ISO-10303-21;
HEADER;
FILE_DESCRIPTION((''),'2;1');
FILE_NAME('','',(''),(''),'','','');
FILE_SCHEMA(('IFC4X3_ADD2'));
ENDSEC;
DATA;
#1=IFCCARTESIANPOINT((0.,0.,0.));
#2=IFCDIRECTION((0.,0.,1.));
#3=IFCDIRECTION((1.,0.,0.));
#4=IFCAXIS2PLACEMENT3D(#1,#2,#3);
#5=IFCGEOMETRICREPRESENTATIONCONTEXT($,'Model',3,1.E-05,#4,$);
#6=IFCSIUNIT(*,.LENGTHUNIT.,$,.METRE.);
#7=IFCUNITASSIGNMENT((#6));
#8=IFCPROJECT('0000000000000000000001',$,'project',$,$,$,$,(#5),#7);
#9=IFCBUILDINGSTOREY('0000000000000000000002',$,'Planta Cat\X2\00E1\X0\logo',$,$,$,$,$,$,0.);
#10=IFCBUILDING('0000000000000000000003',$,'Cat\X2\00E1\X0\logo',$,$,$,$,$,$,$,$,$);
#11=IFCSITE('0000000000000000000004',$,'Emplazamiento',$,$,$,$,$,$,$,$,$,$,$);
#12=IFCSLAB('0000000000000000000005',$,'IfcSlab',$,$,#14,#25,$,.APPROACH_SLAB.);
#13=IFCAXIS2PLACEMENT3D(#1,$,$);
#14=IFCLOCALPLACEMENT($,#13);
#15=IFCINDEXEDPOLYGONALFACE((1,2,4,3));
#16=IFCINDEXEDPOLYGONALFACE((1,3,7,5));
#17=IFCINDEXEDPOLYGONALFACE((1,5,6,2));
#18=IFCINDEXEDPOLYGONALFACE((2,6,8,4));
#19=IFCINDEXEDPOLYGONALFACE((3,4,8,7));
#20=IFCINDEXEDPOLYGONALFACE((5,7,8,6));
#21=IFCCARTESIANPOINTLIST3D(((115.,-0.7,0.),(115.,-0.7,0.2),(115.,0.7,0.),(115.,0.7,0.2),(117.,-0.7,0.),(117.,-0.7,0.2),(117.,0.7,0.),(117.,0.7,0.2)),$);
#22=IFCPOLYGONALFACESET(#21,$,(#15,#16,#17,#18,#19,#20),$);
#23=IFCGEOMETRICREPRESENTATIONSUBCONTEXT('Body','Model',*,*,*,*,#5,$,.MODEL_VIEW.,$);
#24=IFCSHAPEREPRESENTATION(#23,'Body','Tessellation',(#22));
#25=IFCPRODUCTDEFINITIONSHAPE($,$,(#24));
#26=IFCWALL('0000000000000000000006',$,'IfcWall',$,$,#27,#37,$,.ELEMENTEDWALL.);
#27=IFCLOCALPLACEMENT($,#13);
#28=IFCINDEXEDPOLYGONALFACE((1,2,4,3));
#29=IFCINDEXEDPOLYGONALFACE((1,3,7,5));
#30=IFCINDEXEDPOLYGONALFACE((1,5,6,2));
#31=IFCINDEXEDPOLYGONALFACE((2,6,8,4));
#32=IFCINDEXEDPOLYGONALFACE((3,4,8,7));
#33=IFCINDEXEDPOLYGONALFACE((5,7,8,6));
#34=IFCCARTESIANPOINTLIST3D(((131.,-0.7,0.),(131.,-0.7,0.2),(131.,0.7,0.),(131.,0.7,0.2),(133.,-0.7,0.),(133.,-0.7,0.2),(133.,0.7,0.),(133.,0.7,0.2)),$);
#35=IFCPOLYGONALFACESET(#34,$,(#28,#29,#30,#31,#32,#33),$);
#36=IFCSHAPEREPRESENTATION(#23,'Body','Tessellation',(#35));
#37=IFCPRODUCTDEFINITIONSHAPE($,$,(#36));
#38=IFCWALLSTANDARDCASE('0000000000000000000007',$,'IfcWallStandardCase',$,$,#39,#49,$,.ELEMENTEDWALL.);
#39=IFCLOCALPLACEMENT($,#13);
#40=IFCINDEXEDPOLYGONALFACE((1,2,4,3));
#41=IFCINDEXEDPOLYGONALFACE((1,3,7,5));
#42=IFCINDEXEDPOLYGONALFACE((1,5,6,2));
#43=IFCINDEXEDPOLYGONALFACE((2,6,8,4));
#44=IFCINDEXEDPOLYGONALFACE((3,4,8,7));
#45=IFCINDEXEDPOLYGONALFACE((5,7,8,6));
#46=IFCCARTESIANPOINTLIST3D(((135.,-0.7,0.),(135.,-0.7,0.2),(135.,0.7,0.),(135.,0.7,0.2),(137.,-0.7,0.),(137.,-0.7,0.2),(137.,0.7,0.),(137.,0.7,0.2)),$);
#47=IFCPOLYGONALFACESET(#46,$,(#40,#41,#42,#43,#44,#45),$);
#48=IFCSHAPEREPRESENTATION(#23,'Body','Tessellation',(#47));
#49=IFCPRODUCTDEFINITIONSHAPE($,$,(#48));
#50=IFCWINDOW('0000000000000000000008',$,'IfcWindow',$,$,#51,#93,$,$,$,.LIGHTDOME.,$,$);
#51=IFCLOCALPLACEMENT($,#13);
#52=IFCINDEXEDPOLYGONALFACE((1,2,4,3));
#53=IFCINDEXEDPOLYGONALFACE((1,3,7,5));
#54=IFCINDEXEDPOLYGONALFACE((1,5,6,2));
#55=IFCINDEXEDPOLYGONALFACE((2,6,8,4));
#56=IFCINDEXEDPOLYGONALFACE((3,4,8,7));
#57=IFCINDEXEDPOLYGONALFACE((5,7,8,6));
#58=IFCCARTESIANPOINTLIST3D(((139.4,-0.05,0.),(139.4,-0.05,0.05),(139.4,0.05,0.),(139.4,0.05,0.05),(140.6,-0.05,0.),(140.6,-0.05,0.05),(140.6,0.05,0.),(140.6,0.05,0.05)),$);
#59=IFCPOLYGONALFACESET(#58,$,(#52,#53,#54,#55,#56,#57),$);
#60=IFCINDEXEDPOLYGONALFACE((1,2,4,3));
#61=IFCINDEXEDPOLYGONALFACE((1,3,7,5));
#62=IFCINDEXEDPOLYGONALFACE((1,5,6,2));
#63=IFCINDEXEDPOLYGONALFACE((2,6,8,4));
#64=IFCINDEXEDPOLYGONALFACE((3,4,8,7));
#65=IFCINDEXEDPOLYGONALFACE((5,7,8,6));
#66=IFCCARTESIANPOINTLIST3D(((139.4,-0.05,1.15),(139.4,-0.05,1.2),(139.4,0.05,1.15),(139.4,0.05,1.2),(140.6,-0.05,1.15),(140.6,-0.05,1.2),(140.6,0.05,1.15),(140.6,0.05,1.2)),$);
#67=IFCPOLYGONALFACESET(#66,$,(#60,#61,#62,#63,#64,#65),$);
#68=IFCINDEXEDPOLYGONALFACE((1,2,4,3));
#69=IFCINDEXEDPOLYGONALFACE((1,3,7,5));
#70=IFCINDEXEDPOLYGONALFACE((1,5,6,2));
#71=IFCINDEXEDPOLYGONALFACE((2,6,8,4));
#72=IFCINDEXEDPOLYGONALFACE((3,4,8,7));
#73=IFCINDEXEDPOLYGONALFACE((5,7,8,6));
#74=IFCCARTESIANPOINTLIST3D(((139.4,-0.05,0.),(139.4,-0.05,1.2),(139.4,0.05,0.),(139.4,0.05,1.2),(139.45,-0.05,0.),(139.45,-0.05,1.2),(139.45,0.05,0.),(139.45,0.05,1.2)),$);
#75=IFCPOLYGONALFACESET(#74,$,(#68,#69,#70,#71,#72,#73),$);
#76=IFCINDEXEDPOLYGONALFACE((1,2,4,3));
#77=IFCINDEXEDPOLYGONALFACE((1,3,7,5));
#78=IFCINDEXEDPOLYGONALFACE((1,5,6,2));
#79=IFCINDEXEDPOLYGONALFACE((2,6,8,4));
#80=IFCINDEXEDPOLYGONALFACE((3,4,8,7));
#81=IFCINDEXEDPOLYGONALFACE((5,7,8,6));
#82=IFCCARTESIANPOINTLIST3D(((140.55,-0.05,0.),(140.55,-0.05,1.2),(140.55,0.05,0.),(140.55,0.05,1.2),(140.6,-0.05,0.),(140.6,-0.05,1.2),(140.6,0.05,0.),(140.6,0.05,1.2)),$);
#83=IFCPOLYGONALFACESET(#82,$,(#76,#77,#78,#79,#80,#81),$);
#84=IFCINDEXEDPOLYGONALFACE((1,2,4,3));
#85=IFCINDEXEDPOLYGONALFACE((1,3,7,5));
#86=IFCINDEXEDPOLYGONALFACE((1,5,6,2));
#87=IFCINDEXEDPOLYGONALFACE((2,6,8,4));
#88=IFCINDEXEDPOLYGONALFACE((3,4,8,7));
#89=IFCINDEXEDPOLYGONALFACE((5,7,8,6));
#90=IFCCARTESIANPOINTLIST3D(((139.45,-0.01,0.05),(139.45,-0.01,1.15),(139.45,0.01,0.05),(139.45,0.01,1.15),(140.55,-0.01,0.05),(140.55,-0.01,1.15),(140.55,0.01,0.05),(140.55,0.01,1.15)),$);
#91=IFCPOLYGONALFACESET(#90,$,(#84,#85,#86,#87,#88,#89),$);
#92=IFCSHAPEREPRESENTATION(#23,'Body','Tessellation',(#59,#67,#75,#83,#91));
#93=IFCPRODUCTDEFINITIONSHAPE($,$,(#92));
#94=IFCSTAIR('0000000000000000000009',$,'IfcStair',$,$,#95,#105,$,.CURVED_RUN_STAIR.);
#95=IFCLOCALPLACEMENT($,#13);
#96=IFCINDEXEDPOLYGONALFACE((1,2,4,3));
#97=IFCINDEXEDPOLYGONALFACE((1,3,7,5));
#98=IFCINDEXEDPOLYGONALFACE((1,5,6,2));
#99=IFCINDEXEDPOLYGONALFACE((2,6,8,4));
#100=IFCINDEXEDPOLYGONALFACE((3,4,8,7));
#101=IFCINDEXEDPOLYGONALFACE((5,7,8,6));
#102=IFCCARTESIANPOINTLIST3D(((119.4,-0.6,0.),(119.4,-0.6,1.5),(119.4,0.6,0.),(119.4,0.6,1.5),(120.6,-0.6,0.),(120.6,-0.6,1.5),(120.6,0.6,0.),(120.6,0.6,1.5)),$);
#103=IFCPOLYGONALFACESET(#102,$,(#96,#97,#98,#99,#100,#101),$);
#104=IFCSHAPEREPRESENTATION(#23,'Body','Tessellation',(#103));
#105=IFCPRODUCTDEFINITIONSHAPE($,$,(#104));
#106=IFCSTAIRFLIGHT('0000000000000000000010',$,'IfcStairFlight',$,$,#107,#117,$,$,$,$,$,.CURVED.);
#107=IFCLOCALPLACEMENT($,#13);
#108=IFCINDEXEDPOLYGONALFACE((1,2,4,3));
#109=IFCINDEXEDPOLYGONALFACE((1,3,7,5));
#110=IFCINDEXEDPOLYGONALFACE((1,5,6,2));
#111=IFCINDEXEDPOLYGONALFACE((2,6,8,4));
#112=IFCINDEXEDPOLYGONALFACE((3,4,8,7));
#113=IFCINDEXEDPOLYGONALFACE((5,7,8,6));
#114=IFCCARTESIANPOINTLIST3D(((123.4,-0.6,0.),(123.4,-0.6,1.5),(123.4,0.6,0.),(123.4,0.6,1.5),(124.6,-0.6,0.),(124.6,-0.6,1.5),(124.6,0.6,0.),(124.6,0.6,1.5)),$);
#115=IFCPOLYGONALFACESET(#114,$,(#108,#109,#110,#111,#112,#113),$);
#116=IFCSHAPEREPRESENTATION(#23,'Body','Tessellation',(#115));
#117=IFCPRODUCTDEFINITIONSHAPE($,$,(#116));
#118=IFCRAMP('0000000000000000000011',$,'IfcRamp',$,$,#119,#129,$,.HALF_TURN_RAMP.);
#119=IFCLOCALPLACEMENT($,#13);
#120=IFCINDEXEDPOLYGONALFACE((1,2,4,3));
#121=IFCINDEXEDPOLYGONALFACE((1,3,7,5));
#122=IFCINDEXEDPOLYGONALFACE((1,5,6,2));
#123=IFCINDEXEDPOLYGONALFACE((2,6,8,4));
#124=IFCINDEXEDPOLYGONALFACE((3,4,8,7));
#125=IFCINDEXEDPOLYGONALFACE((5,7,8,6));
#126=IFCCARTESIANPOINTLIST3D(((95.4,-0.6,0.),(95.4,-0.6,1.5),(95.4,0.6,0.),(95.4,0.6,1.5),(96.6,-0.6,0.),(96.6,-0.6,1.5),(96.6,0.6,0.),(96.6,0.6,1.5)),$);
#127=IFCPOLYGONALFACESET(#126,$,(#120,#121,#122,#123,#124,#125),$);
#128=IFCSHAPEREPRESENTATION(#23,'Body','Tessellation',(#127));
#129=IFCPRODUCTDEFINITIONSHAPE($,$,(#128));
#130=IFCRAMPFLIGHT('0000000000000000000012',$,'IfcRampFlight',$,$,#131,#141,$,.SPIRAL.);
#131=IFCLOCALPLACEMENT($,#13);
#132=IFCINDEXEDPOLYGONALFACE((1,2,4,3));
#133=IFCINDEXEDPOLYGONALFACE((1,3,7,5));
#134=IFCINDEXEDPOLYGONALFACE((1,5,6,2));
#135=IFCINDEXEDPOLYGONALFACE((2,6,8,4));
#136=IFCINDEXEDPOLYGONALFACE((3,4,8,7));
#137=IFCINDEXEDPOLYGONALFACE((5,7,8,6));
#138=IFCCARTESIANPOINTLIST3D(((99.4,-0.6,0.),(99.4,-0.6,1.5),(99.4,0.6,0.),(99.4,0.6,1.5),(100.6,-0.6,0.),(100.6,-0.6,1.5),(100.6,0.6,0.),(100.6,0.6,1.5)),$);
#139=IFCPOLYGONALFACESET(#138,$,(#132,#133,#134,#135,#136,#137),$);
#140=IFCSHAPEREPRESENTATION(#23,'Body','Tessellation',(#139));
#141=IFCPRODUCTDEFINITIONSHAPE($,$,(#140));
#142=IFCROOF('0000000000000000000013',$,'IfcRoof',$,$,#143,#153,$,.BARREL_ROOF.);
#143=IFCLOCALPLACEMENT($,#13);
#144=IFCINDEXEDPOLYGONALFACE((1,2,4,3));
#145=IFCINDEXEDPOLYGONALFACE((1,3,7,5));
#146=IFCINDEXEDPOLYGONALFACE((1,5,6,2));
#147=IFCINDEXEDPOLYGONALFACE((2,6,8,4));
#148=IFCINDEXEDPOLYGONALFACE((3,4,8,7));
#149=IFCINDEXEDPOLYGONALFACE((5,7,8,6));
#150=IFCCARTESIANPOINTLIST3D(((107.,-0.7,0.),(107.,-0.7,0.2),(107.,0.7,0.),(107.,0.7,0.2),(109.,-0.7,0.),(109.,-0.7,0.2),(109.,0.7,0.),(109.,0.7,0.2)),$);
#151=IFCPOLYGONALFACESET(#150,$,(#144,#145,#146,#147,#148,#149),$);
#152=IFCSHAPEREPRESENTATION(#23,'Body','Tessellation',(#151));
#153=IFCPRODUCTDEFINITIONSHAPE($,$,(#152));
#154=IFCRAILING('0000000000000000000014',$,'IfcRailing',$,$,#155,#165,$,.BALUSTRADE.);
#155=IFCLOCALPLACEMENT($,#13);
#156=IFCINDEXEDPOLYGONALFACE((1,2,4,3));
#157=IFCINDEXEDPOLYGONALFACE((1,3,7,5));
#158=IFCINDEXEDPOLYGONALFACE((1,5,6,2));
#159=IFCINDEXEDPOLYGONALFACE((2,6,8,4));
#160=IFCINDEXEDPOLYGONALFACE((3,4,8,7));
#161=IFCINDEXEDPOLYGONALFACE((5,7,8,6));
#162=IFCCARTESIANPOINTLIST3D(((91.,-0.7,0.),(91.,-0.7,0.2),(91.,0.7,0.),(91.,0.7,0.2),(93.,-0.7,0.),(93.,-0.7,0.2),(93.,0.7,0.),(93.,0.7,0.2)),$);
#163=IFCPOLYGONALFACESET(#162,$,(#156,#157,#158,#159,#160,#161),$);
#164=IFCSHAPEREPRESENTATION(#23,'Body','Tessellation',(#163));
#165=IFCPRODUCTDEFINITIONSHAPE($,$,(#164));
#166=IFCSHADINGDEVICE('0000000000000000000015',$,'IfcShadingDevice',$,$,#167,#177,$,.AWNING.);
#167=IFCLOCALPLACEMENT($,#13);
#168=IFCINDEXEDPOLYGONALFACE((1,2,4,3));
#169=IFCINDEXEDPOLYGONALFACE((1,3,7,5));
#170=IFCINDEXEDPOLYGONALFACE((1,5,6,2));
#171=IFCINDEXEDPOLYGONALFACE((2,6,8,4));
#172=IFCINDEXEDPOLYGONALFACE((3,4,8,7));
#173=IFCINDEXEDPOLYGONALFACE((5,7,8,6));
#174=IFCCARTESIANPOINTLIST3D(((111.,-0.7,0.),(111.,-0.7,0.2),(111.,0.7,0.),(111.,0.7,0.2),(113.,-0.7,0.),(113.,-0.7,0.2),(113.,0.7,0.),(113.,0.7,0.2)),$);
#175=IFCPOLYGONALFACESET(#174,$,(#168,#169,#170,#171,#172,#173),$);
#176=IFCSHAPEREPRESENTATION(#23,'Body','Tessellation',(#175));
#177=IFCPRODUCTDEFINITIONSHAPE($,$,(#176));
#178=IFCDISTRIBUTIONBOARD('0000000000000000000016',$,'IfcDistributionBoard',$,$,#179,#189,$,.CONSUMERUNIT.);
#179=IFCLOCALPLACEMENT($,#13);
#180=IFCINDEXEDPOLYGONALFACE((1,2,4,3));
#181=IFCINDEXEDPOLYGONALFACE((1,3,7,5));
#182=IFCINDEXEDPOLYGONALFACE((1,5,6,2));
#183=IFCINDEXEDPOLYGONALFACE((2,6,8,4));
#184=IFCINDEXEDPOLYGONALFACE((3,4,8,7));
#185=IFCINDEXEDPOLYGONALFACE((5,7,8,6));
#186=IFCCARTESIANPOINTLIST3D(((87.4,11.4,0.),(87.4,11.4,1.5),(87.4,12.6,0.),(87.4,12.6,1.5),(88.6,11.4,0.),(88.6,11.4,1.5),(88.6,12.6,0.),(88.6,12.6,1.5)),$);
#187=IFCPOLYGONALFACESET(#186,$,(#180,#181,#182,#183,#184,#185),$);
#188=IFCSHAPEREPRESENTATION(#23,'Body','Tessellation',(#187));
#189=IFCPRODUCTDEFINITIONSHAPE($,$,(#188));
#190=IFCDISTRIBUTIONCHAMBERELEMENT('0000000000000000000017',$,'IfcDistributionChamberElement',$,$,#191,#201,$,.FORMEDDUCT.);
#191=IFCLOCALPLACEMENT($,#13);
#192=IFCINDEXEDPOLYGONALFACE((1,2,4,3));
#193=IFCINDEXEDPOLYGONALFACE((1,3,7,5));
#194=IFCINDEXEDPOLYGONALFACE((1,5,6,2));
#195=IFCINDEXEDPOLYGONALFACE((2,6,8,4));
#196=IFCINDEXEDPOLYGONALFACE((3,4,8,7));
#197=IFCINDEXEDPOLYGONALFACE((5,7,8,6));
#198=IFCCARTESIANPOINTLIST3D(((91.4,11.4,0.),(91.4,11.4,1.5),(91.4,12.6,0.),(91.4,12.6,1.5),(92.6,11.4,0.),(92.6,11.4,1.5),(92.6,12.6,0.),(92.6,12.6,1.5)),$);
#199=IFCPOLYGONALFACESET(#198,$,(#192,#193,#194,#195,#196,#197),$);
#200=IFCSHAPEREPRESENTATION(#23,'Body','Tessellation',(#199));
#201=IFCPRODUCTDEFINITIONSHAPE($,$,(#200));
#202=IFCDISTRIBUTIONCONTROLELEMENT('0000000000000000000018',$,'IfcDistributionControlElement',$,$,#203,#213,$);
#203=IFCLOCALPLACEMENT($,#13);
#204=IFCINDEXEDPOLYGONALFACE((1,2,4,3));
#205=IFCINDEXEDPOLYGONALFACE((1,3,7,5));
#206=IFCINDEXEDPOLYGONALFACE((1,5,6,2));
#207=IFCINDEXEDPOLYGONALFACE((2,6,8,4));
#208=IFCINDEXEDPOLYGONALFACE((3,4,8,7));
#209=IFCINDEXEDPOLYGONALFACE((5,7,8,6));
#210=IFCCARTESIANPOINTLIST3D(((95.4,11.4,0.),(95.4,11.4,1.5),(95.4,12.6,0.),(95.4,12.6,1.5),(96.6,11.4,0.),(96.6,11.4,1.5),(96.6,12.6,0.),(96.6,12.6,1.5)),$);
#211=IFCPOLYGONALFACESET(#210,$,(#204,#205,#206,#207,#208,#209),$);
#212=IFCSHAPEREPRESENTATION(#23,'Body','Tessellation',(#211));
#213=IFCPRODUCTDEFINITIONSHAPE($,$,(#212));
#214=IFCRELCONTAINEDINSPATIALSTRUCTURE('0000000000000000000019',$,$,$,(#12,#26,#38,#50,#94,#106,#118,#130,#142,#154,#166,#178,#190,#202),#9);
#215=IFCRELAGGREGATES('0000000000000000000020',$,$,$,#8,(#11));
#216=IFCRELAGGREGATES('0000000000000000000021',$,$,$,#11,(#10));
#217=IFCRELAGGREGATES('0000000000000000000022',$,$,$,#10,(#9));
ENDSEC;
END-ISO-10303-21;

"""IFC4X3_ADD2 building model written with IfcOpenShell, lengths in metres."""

from ifc_helpers import new_model, si_unit, frame, origin, origin_with_axes, origin_2d, place, context, subcontext, project, spatial, rectangle, extrude, element, save


model = new_model("IFC4X3_ADD2")

# Units and contexts
model_context = context("Model", 3, precision=1e-05, world=origin_with_axes())
body_context = subcontext(model_context, "Body", "Model", "MODEL_VIEW")
ifc_project = project(units=[si_unit("LENGTHUNIT", "METRE")], contexts=[model_context])

# Site, building, storey
site = spatial("IfcSite", under=ifc_project, Name="Emplazamiento")
building = spatial("IfcBuilding", under=site, Name="Catálogo")
storey = spatial("IfcBuildingStorey", under=building, Name="Planta Catálogo", Elevation=0.0)

# Slab
slab_placement = place(None, frame((116.0, 0.0, 0.0), z_axis=(0.0, 0.0, 1.0), x_axis=(1.0, 0.0, 0.0)))
element("IfcSlab", 1, at=slab_placement, inside=storey, Name="IfcSlab", PredefinedType="APPROACH_SLAB", context=body_context, shape_type="SweptSolid", body=[
    extrude(rectangle(XDim=2.0, YDim=1.4, at=origin_2d()), origin(), (0.0, 0.0, 1.0), 0.2),
])

# Walls
wall_1_placement = place(None, frame((132.0, 0.0, 0.0), z_axis=(0.0, 0.0, 1.0), x_axis=(1.0, 0.0, 0.0)))
element("IfcWall", 2, at=wall_1_placement, inside=storey, Name="IfcWall", PredefinedType="ELEMENTEDWALL", context=body_context, shape_type="SweptSolid", body=[
    extrude(rectangle(XDim=2.0, YDim=1.4, at=origin_2d()), origin(), (0.0, 0.0, 1.0), 0.2),
])
wall_2_placement = place(None, frame((136.0, 0.0, 0.0), z_axis=(0.0, 0.0, 1.0), x_axis=(1.0, 0.0, 0.0)))
element("IfcWallStandardCase", 3, at=wall_2_placement, inside=storey, Name="IfcWallStandardCase", PredefinedType="ELEMENTEDWALL", context=body_context, shape_type="SweptSolid", body=[
    extrude(rectangle(XDim=2.0, YDim=1.4, at=origin_2d()), origin(), (0.0, 0.0, 1.0), 0.2),
])

# Window
window_placement = place(None, frame((140.0, 0.0, 0.0), z_axis=(0.0, 0.0, 1.0), x_axis=(1.0, 0.0, 0.0)))
element("IfcWindow", 4, at=window_placement, inside=storey, Name="IfcWindow", PredefinedType="LIGHTDOME", context=body_context, shape_type="SweptSolid", body=[
    extrude(rectangle(XDim=1.2, YDim=0.1, at=origin_2d()), origin(), (0.0, 0.0, 1.0), 0.05),
    extrude(rectangle(XDim=1.2, YDim=0.1, at=origin_2d()), frame((0.0, 0.0, 1.15)), (0.0, 0.0, 1.0), 0.05),
    extrude(rectangle(XDim=0.05, YDim=0.1, at=origin_2d()), frame((-0.575, 0.0, 0.0)), (0.0, 0.0, 1.0), 1.2),
    extrude(rectangle(XDim=0.05, YDim=0.1, at=origin_2d()), frame((0.575, 0.0, 0.0)), (0.0, 0.0, 1.0), 1.2),
    extrude(rectangle(XDim=1.1, YDim=0.02, at=origin_2d()), frame((0.0, 0.0, 0.05)), (0.0, 0.0, 1.0), 1.1),
])

# Stair
stair_placement = place(None, frame((120.0, 0.0, 0.0), z_axis=(0.0, 0.0, 1.0), x_axis=(1.0, 0.0, 0.0)))
element("IfcStair", 5, at=stair_placement, inside=storey, Name="IfcStair", PredefinedType="CURVED_RUN_STAIR", context=body_context, shape_type="SweptSolid", body=[
    extrude(rectangle(XDim=1.2, YDim=1.2, at=origin_2d()), origin(), (0.0, 0.0, 1.0), 1.5),
])

# Stair flight
stair_flight_placement = place(None, frame((124.0, 0.0, 0.0), z_axis=(0.0, 0.0, 1.0), x_axis=(1.0, 0.0, 0.0)))
element("IfcStairFlight", 6, at=stair_flight_placement, inside=storey, Name="IfcStairFlight", PredefinedType="CURVED", context=body_context, shape_type="SweptSolid", body=[
    extrude(rectangle(XDim=1.2, YDim=1.2, at=origin_2d()), origin(), (0.0, 0.0, 1.0), 1.5),
])

# Ramp
ramp_placement = place(None, frame((96.0, 0.0, 0.0), z_axis=(0.0, 0.0, 1.0), x_axis=(1.0, 0.0, 0.0)))
element("IfcRamp", 7, at=ramp_placement, inside=storey, Name="IfcRamp", PredefinedType="HALF_TURN_RAMP", context=body_context, shape_type="SweptSolid", body=[
    extrude(rectangle(XDim=1.2, YDim=1.2, at=origin_2d()), origin(), (0.0, 0.0, 1.0), 1.5),
])

# Ramp flight
ramp_flight_placement = place(None, frame((100.0, 0.0, 0.0), z_axis=(0.0, 0.0, 1.0), x_axis=(1.0, 0.0, 0.0)))
element("IfcRampFlight", 8, at=ramp_flight_placement, inside=storey, Name="IfcRampFlight", PredefinedType="SPIRAL", context=body_context, shape_type="SweptSolid", body=[
    extrude(rectangle(XDim=1.2, YDim=1.2, at=origin_2d()), origin(), (0.0, 0.0, 1.0), 1.5),
])

# Roof
roof_placement = place(None, frame((108.0, 0.0, 0.0), z_axis=(0.0, 0.0, 1.0), x_axis=(1.0, 0.0, 0.0)))
element("IfcRoof", 9, at=roof_placement, inside=storey, Name="IfcRoof", PredefinedType="BARREL_ROOF", context=body_context, shape_type="SweptSolid", body=[
    extrude(rectangle(XDim=2.0, YDim=1.4, at=origin_2d()), origin(), (0.0, 0.0, 1.0), 0.2),
])

# Railing
railing_placement = place(None, frame((92.0, 0.0, 0.0), z_axis=(0.0, 0.0, 1.0), x_axis=(1.0, 0.0, 0.0)))
element("IfcRailing", 10, at=railing_placement, inside=storey, Name="IfcRailing", PredefinedType="BALUSTRADE", context=body_context, shape_type="SweptSolid", body=[
    extrude(rectangle(XDim=2.0, YDim=1.4, at=origin_2d()), origin(), (0.0, 0.0, 1.0), 0.2),
])

# Shading device
shading_device_placement = place(None, frame((112.0, 0.0, 0.0), z_axis=(0.0, 0.0, 1.0), x_axis=(1.0, 0.0, 0.0)))
element("IfcShadingDevice", 11, at=shading_device_placement, inside=storey, Name="IfcShadingDevice", PredefinedType="AWNING", context=body_context, shape_type="SweptSolid", body=[
    extrude(rectangle(XDim=2.0, YDim=1.4, at=origin_2d()), origin(), (0.0, 0.0, 1.0), 0.2),
])

# Distribution board
distribution_board_placement = place(None, frame((88.0, 12.0, 0.0), z_axis=(0.0, 0.0, 1.0), x_axis=(1.0, 0.0, 0.0)))
element("IfcDistributionBoard", 12, at=distribution_board_placement, inside=storey, Name="IfcDistributionBoard", PredefinedType="CONSUMERUNIT", context=body_context, shape_type="SweptSolid", body=[
    extrude(rectangle(XDim=1.2, YDim=1.2, at=origin_2d()), origin(), (0.0, 0.0, 1.0), 1.5),
])

# Distribution chamber element
distribution_chamber_element_placement = place(None, frame((92.0, 12.0, 0.0), z_axis=(0.0, 0.0, 1.0), x_axis=(1.0, 0.0, 0.0)))
element("IfcDistributionChamberElement", 13, at=distribution_chamber_element_placement, inside=storey, Name="IfcDistributionChamberElement", PredefinedType="FORMEDDUCT", context=body_context, shape_type="SweptSolid", body=[
    extrude(rectangle(XDim=1.2, YDim=1.2, at=origin_2d()), origin(), (0.0, 0.0, 1.0), 1.5),
])

# Distribution control element
distribution_control_element_placement = place(None, frame((96.0, 12.0, 0.0), z_axis=(0.0, 0.0, 1.0), x_axis=(1.0, 0.0, 0.0)))
element("IfcDistributionControlElement", 14, at=distribution_control_element_placement, inside=storey, Name="IfcDistributionControlElement", context=body_context, shape_type="SweptSolid", body=[
    extrude(rectangle(XDim=1.2, YDim=1.2, at=origin_2d()), origin(), (0.0, 0.0, 1.0), 1.5),
])

save(model, "model.ifc")
